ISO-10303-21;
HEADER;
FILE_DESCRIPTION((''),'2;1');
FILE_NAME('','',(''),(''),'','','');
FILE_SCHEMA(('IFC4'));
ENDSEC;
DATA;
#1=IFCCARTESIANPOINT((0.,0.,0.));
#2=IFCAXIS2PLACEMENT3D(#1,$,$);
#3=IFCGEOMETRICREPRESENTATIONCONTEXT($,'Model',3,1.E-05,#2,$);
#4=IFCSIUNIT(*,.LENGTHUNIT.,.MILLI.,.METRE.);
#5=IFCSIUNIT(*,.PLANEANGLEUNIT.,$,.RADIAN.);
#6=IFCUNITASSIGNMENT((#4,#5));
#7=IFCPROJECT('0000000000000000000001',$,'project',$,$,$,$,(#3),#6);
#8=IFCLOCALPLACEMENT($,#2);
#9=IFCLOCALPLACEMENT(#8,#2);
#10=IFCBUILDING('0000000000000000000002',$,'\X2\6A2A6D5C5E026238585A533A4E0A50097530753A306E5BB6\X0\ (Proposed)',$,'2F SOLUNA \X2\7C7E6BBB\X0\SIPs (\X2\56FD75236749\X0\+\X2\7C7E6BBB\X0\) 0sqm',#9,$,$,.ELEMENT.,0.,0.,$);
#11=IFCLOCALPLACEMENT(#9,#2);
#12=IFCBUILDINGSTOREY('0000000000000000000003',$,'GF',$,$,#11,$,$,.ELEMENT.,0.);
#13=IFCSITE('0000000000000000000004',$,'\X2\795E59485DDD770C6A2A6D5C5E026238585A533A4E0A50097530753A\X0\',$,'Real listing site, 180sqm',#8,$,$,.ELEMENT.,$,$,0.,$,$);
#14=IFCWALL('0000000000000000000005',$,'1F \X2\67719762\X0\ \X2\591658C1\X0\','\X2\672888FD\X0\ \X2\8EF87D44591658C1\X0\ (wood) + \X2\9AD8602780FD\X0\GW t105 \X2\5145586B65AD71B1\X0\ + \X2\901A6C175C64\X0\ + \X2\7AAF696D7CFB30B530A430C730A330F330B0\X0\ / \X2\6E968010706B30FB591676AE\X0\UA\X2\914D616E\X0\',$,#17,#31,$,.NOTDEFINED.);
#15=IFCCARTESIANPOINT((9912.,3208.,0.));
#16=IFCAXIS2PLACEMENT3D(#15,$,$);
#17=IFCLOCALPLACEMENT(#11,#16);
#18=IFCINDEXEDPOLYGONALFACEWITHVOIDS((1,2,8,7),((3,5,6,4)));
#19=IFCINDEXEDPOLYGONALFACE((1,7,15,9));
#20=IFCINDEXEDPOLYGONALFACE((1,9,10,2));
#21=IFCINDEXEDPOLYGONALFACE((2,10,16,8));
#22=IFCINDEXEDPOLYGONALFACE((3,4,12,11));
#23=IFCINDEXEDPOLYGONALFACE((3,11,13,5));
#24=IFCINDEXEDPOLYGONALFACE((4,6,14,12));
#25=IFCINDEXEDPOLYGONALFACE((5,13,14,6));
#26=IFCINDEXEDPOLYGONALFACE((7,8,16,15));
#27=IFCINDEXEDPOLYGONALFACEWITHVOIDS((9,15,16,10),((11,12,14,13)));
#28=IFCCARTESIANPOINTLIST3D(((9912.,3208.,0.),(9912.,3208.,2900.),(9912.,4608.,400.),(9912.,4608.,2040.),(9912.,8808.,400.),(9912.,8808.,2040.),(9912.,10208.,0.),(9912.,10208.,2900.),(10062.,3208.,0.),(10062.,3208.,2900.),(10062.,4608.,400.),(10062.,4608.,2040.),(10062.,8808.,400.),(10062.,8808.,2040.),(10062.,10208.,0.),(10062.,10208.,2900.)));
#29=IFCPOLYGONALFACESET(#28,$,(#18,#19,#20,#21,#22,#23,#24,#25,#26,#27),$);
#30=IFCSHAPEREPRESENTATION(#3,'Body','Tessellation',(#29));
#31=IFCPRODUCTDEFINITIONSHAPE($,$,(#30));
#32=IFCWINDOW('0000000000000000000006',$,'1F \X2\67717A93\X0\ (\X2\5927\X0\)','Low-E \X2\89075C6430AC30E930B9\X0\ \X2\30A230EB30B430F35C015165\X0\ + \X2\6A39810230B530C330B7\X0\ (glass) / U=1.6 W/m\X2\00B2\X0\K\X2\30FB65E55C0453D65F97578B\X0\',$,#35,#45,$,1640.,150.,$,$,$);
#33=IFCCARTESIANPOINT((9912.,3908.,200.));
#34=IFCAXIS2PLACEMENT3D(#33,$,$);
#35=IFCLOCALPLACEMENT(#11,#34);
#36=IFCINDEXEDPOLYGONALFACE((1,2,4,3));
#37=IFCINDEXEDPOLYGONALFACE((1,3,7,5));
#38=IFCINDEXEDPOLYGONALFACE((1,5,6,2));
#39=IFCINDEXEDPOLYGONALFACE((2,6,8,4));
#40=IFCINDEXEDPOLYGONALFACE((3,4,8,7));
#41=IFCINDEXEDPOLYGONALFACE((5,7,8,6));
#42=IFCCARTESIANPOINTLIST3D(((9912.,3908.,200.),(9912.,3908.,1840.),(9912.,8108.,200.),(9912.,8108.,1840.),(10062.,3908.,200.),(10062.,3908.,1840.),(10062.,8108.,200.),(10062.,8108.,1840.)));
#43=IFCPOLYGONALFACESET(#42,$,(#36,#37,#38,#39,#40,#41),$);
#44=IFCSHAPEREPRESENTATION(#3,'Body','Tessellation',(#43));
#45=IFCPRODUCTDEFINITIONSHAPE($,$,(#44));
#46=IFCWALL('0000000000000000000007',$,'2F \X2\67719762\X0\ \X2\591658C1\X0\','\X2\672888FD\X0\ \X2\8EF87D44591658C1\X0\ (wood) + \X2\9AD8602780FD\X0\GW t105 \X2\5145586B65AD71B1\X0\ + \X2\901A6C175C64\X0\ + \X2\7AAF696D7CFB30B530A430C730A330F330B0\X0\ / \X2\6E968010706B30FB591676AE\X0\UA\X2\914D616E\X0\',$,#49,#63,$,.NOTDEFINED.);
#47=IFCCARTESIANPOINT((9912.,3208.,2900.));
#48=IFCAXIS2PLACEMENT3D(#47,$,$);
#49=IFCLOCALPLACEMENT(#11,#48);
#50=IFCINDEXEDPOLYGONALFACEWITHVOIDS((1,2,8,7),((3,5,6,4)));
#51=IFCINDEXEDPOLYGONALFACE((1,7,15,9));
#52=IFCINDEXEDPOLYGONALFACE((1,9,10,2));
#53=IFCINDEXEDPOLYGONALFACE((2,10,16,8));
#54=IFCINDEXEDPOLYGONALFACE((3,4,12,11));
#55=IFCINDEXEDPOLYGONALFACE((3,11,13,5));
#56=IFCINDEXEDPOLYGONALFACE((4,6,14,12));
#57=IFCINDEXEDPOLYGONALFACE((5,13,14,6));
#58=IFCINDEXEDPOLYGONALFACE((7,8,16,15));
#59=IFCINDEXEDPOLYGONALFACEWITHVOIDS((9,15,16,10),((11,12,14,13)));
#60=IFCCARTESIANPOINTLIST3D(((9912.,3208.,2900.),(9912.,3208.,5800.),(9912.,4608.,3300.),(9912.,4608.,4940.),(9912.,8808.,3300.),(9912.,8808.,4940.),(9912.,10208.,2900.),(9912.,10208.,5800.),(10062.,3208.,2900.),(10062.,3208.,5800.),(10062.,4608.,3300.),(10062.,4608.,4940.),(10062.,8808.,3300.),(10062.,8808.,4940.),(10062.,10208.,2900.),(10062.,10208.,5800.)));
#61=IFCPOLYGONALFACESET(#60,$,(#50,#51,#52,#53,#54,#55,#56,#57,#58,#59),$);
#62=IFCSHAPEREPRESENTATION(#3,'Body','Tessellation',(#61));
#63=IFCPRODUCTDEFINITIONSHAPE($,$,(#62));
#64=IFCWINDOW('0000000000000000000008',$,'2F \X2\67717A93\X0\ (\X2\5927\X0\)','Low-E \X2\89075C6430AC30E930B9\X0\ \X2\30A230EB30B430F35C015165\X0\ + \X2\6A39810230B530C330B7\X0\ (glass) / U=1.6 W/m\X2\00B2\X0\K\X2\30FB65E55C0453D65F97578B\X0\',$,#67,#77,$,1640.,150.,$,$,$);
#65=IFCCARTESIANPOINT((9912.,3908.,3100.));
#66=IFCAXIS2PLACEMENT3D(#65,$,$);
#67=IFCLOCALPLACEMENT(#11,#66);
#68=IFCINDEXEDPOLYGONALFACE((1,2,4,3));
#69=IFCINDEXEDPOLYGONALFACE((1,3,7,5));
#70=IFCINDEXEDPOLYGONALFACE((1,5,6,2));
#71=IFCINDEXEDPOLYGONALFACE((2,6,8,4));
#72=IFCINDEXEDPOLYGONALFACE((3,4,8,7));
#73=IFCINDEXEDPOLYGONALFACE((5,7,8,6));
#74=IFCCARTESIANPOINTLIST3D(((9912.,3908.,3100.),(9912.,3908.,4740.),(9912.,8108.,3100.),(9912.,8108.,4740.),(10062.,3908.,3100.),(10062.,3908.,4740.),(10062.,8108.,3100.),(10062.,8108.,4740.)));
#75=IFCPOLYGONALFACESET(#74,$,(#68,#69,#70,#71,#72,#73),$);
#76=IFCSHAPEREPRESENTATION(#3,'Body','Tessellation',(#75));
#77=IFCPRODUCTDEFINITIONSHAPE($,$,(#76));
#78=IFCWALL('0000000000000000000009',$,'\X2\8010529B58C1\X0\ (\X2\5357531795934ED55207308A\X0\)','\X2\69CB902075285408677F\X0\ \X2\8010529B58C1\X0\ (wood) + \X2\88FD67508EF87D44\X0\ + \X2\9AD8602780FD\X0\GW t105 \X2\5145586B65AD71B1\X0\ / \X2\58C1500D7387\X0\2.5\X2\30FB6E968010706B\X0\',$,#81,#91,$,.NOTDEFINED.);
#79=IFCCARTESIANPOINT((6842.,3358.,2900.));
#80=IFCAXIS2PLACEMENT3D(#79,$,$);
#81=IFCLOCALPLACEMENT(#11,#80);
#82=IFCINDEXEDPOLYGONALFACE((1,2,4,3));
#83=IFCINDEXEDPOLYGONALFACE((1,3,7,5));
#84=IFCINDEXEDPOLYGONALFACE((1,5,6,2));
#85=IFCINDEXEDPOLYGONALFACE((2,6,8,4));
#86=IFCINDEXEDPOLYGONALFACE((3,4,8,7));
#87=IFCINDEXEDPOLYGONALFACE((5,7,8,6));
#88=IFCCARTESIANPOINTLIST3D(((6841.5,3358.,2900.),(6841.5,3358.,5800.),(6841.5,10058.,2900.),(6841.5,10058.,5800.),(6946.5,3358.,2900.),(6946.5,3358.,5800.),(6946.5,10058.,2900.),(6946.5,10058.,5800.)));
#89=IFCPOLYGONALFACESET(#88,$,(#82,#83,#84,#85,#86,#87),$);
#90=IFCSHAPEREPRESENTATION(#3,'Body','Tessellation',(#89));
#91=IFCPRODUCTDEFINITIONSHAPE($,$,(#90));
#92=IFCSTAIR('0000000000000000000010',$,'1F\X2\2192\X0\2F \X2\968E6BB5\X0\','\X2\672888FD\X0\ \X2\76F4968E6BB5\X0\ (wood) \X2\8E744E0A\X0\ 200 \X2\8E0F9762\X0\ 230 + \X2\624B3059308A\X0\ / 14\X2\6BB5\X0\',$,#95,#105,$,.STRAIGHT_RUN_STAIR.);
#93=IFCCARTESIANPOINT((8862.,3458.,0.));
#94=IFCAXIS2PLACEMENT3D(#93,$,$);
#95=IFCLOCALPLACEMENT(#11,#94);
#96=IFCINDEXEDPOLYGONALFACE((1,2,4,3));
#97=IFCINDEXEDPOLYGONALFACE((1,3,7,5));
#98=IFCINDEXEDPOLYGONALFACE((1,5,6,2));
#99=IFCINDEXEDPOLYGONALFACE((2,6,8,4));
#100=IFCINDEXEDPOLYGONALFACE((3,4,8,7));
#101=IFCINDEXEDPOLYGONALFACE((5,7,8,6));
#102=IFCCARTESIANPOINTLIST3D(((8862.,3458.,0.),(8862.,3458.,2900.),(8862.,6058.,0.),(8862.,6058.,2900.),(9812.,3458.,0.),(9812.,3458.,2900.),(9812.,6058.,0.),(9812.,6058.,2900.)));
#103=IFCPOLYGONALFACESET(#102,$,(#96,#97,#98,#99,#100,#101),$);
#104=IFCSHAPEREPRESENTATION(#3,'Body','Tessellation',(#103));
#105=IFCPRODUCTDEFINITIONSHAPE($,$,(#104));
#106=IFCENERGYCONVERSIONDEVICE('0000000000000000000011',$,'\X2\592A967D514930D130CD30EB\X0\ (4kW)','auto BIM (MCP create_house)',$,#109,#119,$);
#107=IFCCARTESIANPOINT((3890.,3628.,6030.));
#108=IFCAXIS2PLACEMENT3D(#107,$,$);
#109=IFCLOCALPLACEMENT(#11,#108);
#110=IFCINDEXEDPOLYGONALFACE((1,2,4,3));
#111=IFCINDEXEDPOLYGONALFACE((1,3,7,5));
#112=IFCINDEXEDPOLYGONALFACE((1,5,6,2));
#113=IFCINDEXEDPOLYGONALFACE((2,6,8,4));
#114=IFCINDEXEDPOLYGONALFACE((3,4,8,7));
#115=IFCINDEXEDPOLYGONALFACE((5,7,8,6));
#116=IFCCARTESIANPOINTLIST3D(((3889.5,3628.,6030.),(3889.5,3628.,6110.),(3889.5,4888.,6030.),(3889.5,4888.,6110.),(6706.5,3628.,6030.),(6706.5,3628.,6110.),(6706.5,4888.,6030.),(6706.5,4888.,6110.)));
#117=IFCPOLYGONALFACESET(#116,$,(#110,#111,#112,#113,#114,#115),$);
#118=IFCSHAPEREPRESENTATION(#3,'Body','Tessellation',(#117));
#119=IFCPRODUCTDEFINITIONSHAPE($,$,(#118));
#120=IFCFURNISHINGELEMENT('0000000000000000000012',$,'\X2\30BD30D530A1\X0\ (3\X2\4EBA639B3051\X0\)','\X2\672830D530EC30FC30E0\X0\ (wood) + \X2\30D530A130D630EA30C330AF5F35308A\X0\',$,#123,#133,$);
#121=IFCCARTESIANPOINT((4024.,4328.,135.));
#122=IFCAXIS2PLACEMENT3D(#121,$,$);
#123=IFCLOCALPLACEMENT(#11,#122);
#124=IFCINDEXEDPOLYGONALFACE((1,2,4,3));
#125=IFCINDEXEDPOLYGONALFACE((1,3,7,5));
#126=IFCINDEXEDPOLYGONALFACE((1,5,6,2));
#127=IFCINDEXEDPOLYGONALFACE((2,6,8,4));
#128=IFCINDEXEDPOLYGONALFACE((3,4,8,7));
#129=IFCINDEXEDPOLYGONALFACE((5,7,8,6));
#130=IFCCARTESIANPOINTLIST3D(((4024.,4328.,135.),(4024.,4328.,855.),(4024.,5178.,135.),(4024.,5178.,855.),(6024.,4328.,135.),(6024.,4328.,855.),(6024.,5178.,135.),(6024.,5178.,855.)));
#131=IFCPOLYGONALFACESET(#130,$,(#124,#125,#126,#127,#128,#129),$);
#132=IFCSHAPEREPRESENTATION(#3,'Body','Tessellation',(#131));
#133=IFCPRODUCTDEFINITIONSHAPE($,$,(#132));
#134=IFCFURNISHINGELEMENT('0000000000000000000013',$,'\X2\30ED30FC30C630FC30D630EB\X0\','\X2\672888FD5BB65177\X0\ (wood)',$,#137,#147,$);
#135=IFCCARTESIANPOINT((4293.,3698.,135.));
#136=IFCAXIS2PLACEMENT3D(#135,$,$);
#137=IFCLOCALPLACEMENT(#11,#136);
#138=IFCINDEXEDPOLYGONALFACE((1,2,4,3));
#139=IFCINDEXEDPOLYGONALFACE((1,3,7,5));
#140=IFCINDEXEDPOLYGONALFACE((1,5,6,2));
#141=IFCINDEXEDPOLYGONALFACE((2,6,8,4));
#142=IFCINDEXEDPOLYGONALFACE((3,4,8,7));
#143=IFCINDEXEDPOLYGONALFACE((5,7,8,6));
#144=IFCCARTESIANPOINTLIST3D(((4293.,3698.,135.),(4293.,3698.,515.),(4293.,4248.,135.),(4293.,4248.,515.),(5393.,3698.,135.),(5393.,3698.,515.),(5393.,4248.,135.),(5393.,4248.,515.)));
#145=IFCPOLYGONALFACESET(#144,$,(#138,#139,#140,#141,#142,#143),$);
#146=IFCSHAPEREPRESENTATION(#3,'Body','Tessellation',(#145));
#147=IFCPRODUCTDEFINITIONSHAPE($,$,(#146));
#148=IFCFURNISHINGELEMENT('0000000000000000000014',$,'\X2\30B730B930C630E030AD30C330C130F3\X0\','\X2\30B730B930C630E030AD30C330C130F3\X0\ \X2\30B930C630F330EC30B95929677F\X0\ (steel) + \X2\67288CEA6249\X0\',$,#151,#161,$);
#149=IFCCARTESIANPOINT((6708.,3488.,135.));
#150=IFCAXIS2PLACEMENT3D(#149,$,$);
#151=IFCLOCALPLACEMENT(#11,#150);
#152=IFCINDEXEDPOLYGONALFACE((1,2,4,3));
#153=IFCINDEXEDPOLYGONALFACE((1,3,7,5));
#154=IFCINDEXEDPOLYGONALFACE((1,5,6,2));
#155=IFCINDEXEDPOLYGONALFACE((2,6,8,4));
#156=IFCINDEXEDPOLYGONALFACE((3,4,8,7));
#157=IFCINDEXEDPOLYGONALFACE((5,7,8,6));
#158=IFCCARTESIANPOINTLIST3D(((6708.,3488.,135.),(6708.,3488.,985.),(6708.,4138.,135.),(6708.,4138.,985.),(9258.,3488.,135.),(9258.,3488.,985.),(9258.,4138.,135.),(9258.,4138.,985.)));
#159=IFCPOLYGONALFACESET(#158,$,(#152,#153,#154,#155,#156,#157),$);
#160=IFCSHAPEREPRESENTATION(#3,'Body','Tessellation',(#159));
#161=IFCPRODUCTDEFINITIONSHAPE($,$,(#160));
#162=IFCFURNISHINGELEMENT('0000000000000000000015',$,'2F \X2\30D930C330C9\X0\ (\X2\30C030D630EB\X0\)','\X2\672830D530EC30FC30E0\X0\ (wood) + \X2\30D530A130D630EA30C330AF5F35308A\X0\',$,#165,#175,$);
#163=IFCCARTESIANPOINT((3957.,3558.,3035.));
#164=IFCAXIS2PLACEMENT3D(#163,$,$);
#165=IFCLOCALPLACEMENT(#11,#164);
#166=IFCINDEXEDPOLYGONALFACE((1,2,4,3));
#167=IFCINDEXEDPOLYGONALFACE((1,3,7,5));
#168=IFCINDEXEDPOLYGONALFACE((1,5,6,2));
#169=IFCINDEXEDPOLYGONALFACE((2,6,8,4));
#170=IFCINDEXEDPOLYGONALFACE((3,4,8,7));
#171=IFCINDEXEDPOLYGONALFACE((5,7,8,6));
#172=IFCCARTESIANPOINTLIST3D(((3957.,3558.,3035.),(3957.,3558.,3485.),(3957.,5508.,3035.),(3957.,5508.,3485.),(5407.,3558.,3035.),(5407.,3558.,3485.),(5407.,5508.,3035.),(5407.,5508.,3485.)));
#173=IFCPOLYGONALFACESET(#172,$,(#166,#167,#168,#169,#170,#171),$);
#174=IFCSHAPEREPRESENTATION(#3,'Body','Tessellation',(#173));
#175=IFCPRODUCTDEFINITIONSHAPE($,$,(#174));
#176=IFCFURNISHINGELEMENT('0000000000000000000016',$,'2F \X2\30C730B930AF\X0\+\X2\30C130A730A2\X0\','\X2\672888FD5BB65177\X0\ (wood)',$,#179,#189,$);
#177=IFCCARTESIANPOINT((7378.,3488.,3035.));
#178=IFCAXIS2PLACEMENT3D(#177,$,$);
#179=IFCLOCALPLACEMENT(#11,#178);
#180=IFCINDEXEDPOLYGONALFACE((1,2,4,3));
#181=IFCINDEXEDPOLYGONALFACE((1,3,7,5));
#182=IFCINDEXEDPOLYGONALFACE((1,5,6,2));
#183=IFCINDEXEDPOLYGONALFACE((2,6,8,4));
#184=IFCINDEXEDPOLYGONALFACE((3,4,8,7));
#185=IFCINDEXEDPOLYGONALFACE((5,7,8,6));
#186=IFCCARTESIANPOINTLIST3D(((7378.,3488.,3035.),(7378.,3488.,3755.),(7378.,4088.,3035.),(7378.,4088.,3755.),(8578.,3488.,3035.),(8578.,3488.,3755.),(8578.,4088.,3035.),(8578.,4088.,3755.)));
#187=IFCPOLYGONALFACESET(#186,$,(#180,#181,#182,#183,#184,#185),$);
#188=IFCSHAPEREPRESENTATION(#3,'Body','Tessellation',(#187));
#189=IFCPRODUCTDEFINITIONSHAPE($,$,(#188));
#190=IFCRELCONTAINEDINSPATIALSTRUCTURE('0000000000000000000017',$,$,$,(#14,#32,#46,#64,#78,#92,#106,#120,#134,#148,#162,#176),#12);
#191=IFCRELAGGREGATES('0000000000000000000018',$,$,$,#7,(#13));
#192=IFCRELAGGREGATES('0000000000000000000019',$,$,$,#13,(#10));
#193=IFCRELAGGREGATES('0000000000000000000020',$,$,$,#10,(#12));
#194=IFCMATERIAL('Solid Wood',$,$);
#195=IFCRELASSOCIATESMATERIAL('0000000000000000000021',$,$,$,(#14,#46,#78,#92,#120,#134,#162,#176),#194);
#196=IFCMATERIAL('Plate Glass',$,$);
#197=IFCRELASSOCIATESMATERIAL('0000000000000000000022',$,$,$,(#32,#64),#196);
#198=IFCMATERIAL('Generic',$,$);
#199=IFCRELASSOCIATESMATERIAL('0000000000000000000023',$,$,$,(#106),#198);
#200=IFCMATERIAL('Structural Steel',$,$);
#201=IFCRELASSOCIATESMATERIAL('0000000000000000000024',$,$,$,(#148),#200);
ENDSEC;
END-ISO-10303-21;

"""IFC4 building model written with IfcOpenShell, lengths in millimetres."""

from ifc_helpers import new_model, si_unit, frame, frame_2d, origin, place, context, project, spatial, rectangle, extrude, material, element, fill, save


model = new_model("IFC4")

# Units and contexts
model_context = context("Model", 3, precision=1e-05, world=origin())
ifc_project = project(units=[si_unit("LENGTHUNIT", "METRE", prefix="MILLI"), si_unit("PLANEANGLEUNIT", "RADIAN")], contexts=[model_context])

# Site, building, storey
site_placement = place(None, origin())
site = spatial("IfcSite", under=ifc_project, at=site_placement, Name="神奈川県横浜市戸塚区上倉田町", ObjectType="Real listing site, 180sqm", CompositionType="ELEMENT", RefElevation=0.0)
building_placement = place(site_placement, origin())
building = spatial("IfcBuilding", under=site, at=building_placement, Name="横浜市戸塚区上倉田町の家 (Proposed)", ObjectType="2F SOLUNA 籾殻SIPs (国産杉+籾殻) 0sqm", CompositionType="ELEMENT", ElevationOfRefHeight=0.0, ElevationOfTerrain=0.0)
storey_placement = place(building_placement, origin())
storey = spatial("IfcBuildingStorey", under=building, at=storey_placement, Name="GF", CompositionType="ELEMENT", Elevation=0.0)

# Wall, opening, window
ifc_material_1 = material(Name="Solid Wood")
wall_1_placement = place(storey_placement, frame((9912.0, 3208.0, 0.0)))
wall_1 = element("IfcWall", 1, at=wall_1_placement, inside=storey, material=ifc_material_1, Name="1F 東面 外壁", Description="木製 軸組外壁 (wood) + 高性能GW t105 充填断熱 + 通気層 + 窯業系サイディング / 準耐火・外皮UA配慮", PredefinedType="NOTDEFINED", context=model_context, shape_type="SweptSolid", body=[
    extrude(rectangle(XDim=150.0, YDim=7000.0, at=frame_2d((75.0, 3500.0))), frame((9912.0, 3208.0, 0.0)), (0.0, 0.0, 1.0), 2900.0),
])
opening_1_placement = place(storey_placement, frame((9912.0, 3908.0, 200.0)))
opening_1 = element("IfcOpeningElement", 2, at=opening_1_placement, cuts=wall_1, PredefinedType="NOTDEFINED", context=model_context, shape_type="SweptSolid", body=[
    extrude(rectangle(XDim=150.0, YDim=4200.0, at=frame_2d((75.0, 2100.0))), frame((9912.0, 3908.0, 200.0)), (0.0, 0.0, 1.0), 1640.0),
])
ifc_material_2 = material(Name="Plate Glass")
window_1_placement = place(storey_placement, frame((9912.0, 3908.0, 200.0)))
window_1 = element("IfcWindow", 3, at=window_1_placement, inside=storey, material=ifc_material_2, Name="1F 東窓 (大)", Description="Low-E 複層ガラス アルゴン封入 + 樹脂サッシ (glass) / U=1.6 W/m²K・日射取得型", OverallHeight=1640.0, OverallWidth=150.0, context=model_context, shape_type="SweptSolid", body=[
    extrude(rectangle(XDim=150.0, YDim=4200.0, at=frame_2d((75.0, 2100.0))), frame((9912.0, 3908.0, 200.0)), (0.0, 0.0, 1.0), 1640.0),
])
fill(opening_1, window_1)

# Wall, opening, window
wall_2_placement = place(storey_placement, frame((9912.0, 3208.0, 2900.0)))
wall_2 = element("IfcWall", 4, at=wall_2_placement, inside=storey, material=ifc_material_1, Name="2F 東面 外壁", Description="木製 軸組外壁 (wood) + 高性能GW t105 充填断熱 + 通気層 + 窯業系サイディング / 準耐火・外皮UA配慮", PredefinedType="NOTDEFINED", context=model_context, shape_type="SweptSolid", body=[
    extrude(rectangle(XDim=150.0, YDim=7000.0, at=frame_2d((75.0, 3500.0))), frame((9912.0, 3208.0, 2900.0)), (0.0, 0.0, 1.0), 2900.0),
])
opening_2_placement = place(storey_placement, frame((9912.0, 3908.0, 3100.0)))
opening_2 = element("IfcOpeningElement", 5, at=opening_2_placement, cuts=wall_2, PredefinedType="NOTDEFINED", context=model_context, shape_type="SweptSolid", body=[
    extrude(rectangle(XDim=150.0, YDim=4200.0, at=frame_2d((75.0, 2100.0))), frame((9912.0, 3908.0, 3100.0)), (0.0, 0.0, 1.0), 1640.0),
])
window_2_placement = place(storey_placement, frame((9912.0, 3908.0, 3100.0)))
window_2 = element("IfcWindow", 6, at=window_2_placement, inside=storey, material=ifc_material_2, Name="2F 東窓 (大)", Description="Low-E 複層ガラス アルゴン封入 + 樹脂サッシ (glass) / U=1.6 W/m²K・日射取得型", OverallHeight=1640.0, OverallWidth=150.0, context=model_context, shape_type="SweptSolid", body=[
    extrude(rectangle(XDim=150.0, YDim=4200.0, at=frame_2d((75.0, 2100.0))), frame((9912.0, 3908.0, 3100.0)), (0.0, 0.0, 1.0), 1640.0),
])
fill(opening_2, window_2)

# Wall
wall_3_placement = place(storey_placement, frame((6842.0, 3358.0, 2900.0)))
element("IfcWall", 7, at=wall_3_placement, inside=storey, material=ifc_material_1, Name="耐力壁 (南北間仕切り)", Description="構造用合板 耐力壁 (wood) + 製材軸組 + 高性能GW t105 充填断熱 / 壁倍率2.5・準耐火", PredefinedType="NOTDEFINED", context=model_context, shape_type="SweptSolid", body=[
    extrude(rectangle(XDim=105.0, YDim=6700.0, at=frame_2d((52.0, 3350.0))), frame((6842.0, 3358.0, 2900.0)), (0.0, 0.0, 1.0), 2900.0),
])

# Stair
stair_placement = place(storey_placement, frame((8862.0, 3458.0, 0.0)))
element("IfcStair", 8, at=stair_placement, inside=storey, material=ifc_material_1, Name="1F→2F 階段", Description="木製 直階段 (wood) 蹴上 200 踏面 230 + 手すり / 14段", PredefinedType="STRAIGHT_RUN_STAIR", context=model_context, shape_type="SweptSolid", body=[
    extrude(rectangle(XDim=950.0, YDim=2600.0, at=frame_2d((475.0, 1300.0))), frame((8862.0, 3458.0, 0.0)), (0.0, 0.0, 1.0), 2900.0),
])

# Energy conversion device
ifc_material_3 = material(Name="Generic")
energy_conversion_device_placement = place(storey_placement, frame((3890.0, 3628.0, 6030.0)))
element("IfcEnergyConversionDevice", 9, at=energy_conversion_device_placement, inside=storey, material=ifc_material_3, Name="太陽光パネル (4kW)", Description="auto BIM (MCP create_house)", context=model_context, shape_type="SweptSolid", body=[
    extrude(rectangle(XDim=2817.0, YDim=1260.0, at=frame_2d((1408.0, 630.0))), frame((3890.0, 3628.0, 6030.0)), (0.0, 0.0, 1.0), 80.0),
])

# Furnishing elements
furnishing_1_placement = place(storey_placement, frame((4024.0, 4328.0, 135.0)))
element("IfcFurnishingElement", 10, at=furnishing_1_placement, inside=storey, material=ifc_material_1, Name="ソファ (3人掛け)", Description="木フレーム (wood) + ファブリック張り", context=model_context, shape_type="SweptSolid", body=[
    extrude(rectangle(XDim=2000.0, YDim=850.0, at=frame_2d((1000.0, 425.0))), frame((4024.0, 4328.0, 135.0)), (0.0, 0.0, 1.0), 720.0),
])
furnishing_2_placement = place(storey_placement, frame((4293.0, 3698.0, 135.0)))
element("IfcFurnishingElement", 11, at=furnishing_2_placement, inside=storey, material=ifc_material_1, Name="ローテーブル", Description="木製家具 (wood)", context=model_context, shape_type="SweptSolid", body=[
    extrude(rectangle(XDim=1100.0, YDim=550.0, at=frame_2d((550.0, 275.0))), frame((4293.0, 3698.0, 135.0)), (0.0, 0.0, 1.0), 380.0),
])
ifc_material_4 = material(Name="Structural Steel")
furnishing_3_placement = place(storey_placement, frame((6708.0, 3488.0, 135.0)))
element("IfcFurnishingElement", 12, at=furnishing_3_placement, inside=storey, material=ifc_material_4, Name="システムキッチン", Description="システムキッチン ステンレス天板 (steel) + 木質扉", context=model_context, shape_type="SweptSolid", body=[
    extrude(rectangle(XDim=2550.0, YDim=650.0, at=frame_2d((1275.0, 325.0))), frame((6708.0, 3488.0, 135.0)), (0.0, 0.0, 1.0), 850.0),
])
furnishing_4_placement = place(storey_placement, frame((3957.0, 3558.0, 3035.0)))
element("IfcFurnishingElement", 13, at=furnishing_4_placement, inside=storey, material=ifc_material_1, Name="2F ベッド (ダブル)", Description="木フレーム (wood) + ファブリック張り", context=model_context, shape_type="SweptSolid", body=[
    extrude(rectangle(XDim=1450.0, YDim=1950.0, at=frame_2d((725.0, 975.0))), frame((3957.0, 3558.0, 3035.0)), (0.0, 0.0, 1.0), 450.0),
])
furnishing_5_placement = place(storey_placement, frame((7378.0, 3488.0, 3035.0)))
element("IfcFurnishingElement", 14, at=furnishing_5_placement, inside=storey, material=ifc_material_1, Name="2F デスク+チェア", Description="木製家具 (wood)", context=model_context, shape_type="SweptSolid", body=[
    extrude(rectangle(XDim=1200.0, YDim=600.0, at=frame_2d((600.0, 300.0))), frame((7378.0, 3488.0, 3035.0)), (0.0, 0.0, 1.0), 720.0),
])

save(model, "model.ifc")
